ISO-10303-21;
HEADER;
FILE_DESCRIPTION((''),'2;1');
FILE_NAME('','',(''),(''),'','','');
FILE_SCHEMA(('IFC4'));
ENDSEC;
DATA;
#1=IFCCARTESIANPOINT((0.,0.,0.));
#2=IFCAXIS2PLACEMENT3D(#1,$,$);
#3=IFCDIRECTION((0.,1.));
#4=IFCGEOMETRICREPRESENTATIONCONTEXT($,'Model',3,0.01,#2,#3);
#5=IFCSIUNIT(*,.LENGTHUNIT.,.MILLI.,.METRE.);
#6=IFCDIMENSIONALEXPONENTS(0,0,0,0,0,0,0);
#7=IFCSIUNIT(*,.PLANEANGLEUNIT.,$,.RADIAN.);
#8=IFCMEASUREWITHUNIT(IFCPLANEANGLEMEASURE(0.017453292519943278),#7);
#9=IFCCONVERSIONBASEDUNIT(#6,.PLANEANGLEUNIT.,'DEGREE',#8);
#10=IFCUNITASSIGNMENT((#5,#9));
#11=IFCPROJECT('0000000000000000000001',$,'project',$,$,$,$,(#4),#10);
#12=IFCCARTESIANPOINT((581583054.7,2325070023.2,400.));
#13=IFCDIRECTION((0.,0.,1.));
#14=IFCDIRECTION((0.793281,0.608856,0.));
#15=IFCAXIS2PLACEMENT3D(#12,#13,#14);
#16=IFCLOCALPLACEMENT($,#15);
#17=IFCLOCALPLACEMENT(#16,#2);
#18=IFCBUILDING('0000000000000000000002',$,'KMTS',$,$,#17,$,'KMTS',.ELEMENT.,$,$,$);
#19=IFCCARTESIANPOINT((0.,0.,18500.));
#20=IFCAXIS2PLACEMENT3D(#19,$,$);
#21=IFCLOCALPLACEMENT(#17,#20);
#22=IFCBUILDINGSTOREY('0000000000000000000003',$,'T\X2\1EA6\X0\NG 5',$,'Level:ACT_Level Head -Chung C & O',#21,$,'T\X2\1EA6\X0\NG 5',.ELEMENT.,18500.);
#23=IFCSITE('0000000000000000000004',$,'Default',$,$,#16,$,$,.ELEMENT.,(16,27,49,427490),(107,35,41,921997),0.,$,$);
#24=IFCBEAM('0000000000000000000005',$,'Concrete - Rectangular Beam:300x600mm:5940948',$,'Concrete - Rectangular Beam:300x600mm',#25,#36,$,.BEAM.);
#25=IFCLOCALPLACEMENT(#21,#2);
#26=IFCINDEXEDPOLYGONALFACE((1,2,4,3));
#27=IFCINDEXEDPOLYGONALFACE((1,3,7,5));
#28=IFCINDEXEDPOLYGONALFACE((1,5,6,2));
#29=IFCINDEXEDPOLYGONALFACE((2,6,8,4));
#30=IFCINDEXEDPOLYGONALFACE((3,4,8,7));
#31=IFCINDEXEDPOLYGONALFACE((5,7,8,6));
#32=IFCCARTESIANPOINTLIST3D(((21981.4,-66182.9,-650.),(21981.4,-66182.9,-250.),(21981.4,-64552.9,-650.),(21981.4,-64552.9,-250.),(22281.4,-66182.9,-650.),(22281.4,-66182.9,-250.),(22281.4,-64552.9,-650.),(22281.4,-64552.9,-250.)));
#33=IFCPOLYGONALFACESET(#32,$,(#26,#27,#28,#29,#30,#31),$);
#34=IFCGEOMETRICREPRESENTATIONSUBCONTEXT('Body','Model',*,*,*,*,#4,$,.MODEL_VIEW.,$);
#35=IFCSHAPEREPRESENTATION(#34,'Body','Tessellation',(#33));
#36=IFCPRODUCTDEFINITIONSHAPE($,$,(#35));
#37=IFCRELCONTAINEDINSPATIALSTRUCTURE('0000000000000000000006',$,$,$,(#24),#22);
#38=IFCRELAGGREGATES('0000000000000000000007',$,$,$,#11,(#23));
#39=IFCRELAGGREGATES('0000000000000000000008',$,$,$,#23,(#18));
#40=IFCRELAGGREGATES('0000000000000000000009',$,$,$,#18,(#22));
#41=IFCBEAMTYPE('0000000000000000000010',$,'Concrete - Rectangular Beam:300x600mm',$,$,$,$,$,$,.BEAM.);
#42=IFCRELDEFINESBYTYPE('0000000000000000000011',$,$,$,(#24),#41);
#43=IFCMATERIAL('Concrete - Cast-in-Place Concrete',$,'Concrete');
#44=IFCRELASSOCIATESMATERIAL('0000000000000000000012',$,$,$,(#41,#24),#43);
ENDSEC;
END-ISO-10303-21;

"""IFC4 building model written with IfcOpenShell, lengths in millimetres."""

from ifc_helpers import new_model, entity, si_unit, converted_unit, direction, frame, origin, place, context, subcontext, project, spatial, indexed_curve, outline, extrude, source, transform, mapped, material, type_object, type_shapes, element, save


model = new_model("IFC4")

# Units and contexts
model_context = context("Model", 3, precision=0.01, world=origin(), true_north=direction((0.0, 1.0)))
body_context = subcontext(model_context, "Body", "Model", "MODEL_VIEW")
ifc_project = project(units=[si_unit("LENGTHUNIT", "METRE", prefix="MILLI"), converted_unit("PLANEANGLEUNIT", "DEGREE", entity("IfcPlaneAngleMeasure", 0.017453292519943278), si_unit("PLANEANGLEUNIT", "RADIAN"), dimensions=[0, 0, 0, 0, 0, 0, 0])], contexts=[model_context])

# Site, building, storey
site_placement = place(None, frame((581583054.7, 2325070023.2, 400.0), z_axis=(0.0, 0.0, 1.0), x_axis=(0.793281, 0.608856, 0.0)))
site = spatial("IfcSite", under=ifc_project, at=site_placement, Name="Default", CompositionType="ELEMENT", RefLatitude=(16, 27, 49, 427490), RefLongitude=(107, 35, 41, 921997), RefElevation=0.0)
building_placement = place(site_placement, origin())
building = spatial("IfcBuilding", under=site, at=building_placement, Name="KMTS", LongName="KMTS", CompositionType="ELEMENT")
storey_placement = place(building_placement, frame((0.0, 0.0, 18500.0)))
storey = spatial("IfcBuildingStorey", under=building, at=storey_placement, Name="TẦNG 5", ObjectType="Level:ACT_Level Head -Chung C & O", LongName="TẦNG 5", CompositionType="ELEMENT", Elevation=18500.0)

# Beam
ifc_material_1 = material(Name="Concrete - Cast-in-Place Concrete", Category="Concrete")
beam_type_1 = type_object("IfcBeamType", Name="Concrete - Rectangular Beam:300x600mm", PredefinedType="BEAM", material=ifc_material_1)
shared_shape_1 = source(origin(), body_context, "Body", "SweptSolid", [
    extrude(outline(indexed_curve([(-150.0, -200.0), (150.0, -200.0), (150.0, 200.0), (-150.0, 200.0), (-150.0, -200.0)], self_intersect=False)), frame((22131.4, -64552.9, 18050.0), z_axis=(0.0, -1.0, 0.0), x_axis=(-1.0, 0.0, 0.0)), (0.0, 0.0, 1.0), 1630.0),
])
type_shapes(beam_type_1, [shared_shape_1])
beam_1_placement = place(storey_placement, frame((0.0, 0.0, -18500.0)))
element("IfcBeam", 1, at=beam_1_placement, inside=storey, type_object=beam_type_1, material=ifc_material_1, Name="Concrete - Rectangular Beam:300x600mm:5940948", ObjectType="Concrete - Rectangular Beam:300x600mm", PredefinedType="BEAM", context=body_context, shape_type="MappedRepresentation", body=[
    mapped(shared_shape_1, transform((0.0, 0.0, 0.0), scale=1.0)),
])

save(model, "model.ifc")
